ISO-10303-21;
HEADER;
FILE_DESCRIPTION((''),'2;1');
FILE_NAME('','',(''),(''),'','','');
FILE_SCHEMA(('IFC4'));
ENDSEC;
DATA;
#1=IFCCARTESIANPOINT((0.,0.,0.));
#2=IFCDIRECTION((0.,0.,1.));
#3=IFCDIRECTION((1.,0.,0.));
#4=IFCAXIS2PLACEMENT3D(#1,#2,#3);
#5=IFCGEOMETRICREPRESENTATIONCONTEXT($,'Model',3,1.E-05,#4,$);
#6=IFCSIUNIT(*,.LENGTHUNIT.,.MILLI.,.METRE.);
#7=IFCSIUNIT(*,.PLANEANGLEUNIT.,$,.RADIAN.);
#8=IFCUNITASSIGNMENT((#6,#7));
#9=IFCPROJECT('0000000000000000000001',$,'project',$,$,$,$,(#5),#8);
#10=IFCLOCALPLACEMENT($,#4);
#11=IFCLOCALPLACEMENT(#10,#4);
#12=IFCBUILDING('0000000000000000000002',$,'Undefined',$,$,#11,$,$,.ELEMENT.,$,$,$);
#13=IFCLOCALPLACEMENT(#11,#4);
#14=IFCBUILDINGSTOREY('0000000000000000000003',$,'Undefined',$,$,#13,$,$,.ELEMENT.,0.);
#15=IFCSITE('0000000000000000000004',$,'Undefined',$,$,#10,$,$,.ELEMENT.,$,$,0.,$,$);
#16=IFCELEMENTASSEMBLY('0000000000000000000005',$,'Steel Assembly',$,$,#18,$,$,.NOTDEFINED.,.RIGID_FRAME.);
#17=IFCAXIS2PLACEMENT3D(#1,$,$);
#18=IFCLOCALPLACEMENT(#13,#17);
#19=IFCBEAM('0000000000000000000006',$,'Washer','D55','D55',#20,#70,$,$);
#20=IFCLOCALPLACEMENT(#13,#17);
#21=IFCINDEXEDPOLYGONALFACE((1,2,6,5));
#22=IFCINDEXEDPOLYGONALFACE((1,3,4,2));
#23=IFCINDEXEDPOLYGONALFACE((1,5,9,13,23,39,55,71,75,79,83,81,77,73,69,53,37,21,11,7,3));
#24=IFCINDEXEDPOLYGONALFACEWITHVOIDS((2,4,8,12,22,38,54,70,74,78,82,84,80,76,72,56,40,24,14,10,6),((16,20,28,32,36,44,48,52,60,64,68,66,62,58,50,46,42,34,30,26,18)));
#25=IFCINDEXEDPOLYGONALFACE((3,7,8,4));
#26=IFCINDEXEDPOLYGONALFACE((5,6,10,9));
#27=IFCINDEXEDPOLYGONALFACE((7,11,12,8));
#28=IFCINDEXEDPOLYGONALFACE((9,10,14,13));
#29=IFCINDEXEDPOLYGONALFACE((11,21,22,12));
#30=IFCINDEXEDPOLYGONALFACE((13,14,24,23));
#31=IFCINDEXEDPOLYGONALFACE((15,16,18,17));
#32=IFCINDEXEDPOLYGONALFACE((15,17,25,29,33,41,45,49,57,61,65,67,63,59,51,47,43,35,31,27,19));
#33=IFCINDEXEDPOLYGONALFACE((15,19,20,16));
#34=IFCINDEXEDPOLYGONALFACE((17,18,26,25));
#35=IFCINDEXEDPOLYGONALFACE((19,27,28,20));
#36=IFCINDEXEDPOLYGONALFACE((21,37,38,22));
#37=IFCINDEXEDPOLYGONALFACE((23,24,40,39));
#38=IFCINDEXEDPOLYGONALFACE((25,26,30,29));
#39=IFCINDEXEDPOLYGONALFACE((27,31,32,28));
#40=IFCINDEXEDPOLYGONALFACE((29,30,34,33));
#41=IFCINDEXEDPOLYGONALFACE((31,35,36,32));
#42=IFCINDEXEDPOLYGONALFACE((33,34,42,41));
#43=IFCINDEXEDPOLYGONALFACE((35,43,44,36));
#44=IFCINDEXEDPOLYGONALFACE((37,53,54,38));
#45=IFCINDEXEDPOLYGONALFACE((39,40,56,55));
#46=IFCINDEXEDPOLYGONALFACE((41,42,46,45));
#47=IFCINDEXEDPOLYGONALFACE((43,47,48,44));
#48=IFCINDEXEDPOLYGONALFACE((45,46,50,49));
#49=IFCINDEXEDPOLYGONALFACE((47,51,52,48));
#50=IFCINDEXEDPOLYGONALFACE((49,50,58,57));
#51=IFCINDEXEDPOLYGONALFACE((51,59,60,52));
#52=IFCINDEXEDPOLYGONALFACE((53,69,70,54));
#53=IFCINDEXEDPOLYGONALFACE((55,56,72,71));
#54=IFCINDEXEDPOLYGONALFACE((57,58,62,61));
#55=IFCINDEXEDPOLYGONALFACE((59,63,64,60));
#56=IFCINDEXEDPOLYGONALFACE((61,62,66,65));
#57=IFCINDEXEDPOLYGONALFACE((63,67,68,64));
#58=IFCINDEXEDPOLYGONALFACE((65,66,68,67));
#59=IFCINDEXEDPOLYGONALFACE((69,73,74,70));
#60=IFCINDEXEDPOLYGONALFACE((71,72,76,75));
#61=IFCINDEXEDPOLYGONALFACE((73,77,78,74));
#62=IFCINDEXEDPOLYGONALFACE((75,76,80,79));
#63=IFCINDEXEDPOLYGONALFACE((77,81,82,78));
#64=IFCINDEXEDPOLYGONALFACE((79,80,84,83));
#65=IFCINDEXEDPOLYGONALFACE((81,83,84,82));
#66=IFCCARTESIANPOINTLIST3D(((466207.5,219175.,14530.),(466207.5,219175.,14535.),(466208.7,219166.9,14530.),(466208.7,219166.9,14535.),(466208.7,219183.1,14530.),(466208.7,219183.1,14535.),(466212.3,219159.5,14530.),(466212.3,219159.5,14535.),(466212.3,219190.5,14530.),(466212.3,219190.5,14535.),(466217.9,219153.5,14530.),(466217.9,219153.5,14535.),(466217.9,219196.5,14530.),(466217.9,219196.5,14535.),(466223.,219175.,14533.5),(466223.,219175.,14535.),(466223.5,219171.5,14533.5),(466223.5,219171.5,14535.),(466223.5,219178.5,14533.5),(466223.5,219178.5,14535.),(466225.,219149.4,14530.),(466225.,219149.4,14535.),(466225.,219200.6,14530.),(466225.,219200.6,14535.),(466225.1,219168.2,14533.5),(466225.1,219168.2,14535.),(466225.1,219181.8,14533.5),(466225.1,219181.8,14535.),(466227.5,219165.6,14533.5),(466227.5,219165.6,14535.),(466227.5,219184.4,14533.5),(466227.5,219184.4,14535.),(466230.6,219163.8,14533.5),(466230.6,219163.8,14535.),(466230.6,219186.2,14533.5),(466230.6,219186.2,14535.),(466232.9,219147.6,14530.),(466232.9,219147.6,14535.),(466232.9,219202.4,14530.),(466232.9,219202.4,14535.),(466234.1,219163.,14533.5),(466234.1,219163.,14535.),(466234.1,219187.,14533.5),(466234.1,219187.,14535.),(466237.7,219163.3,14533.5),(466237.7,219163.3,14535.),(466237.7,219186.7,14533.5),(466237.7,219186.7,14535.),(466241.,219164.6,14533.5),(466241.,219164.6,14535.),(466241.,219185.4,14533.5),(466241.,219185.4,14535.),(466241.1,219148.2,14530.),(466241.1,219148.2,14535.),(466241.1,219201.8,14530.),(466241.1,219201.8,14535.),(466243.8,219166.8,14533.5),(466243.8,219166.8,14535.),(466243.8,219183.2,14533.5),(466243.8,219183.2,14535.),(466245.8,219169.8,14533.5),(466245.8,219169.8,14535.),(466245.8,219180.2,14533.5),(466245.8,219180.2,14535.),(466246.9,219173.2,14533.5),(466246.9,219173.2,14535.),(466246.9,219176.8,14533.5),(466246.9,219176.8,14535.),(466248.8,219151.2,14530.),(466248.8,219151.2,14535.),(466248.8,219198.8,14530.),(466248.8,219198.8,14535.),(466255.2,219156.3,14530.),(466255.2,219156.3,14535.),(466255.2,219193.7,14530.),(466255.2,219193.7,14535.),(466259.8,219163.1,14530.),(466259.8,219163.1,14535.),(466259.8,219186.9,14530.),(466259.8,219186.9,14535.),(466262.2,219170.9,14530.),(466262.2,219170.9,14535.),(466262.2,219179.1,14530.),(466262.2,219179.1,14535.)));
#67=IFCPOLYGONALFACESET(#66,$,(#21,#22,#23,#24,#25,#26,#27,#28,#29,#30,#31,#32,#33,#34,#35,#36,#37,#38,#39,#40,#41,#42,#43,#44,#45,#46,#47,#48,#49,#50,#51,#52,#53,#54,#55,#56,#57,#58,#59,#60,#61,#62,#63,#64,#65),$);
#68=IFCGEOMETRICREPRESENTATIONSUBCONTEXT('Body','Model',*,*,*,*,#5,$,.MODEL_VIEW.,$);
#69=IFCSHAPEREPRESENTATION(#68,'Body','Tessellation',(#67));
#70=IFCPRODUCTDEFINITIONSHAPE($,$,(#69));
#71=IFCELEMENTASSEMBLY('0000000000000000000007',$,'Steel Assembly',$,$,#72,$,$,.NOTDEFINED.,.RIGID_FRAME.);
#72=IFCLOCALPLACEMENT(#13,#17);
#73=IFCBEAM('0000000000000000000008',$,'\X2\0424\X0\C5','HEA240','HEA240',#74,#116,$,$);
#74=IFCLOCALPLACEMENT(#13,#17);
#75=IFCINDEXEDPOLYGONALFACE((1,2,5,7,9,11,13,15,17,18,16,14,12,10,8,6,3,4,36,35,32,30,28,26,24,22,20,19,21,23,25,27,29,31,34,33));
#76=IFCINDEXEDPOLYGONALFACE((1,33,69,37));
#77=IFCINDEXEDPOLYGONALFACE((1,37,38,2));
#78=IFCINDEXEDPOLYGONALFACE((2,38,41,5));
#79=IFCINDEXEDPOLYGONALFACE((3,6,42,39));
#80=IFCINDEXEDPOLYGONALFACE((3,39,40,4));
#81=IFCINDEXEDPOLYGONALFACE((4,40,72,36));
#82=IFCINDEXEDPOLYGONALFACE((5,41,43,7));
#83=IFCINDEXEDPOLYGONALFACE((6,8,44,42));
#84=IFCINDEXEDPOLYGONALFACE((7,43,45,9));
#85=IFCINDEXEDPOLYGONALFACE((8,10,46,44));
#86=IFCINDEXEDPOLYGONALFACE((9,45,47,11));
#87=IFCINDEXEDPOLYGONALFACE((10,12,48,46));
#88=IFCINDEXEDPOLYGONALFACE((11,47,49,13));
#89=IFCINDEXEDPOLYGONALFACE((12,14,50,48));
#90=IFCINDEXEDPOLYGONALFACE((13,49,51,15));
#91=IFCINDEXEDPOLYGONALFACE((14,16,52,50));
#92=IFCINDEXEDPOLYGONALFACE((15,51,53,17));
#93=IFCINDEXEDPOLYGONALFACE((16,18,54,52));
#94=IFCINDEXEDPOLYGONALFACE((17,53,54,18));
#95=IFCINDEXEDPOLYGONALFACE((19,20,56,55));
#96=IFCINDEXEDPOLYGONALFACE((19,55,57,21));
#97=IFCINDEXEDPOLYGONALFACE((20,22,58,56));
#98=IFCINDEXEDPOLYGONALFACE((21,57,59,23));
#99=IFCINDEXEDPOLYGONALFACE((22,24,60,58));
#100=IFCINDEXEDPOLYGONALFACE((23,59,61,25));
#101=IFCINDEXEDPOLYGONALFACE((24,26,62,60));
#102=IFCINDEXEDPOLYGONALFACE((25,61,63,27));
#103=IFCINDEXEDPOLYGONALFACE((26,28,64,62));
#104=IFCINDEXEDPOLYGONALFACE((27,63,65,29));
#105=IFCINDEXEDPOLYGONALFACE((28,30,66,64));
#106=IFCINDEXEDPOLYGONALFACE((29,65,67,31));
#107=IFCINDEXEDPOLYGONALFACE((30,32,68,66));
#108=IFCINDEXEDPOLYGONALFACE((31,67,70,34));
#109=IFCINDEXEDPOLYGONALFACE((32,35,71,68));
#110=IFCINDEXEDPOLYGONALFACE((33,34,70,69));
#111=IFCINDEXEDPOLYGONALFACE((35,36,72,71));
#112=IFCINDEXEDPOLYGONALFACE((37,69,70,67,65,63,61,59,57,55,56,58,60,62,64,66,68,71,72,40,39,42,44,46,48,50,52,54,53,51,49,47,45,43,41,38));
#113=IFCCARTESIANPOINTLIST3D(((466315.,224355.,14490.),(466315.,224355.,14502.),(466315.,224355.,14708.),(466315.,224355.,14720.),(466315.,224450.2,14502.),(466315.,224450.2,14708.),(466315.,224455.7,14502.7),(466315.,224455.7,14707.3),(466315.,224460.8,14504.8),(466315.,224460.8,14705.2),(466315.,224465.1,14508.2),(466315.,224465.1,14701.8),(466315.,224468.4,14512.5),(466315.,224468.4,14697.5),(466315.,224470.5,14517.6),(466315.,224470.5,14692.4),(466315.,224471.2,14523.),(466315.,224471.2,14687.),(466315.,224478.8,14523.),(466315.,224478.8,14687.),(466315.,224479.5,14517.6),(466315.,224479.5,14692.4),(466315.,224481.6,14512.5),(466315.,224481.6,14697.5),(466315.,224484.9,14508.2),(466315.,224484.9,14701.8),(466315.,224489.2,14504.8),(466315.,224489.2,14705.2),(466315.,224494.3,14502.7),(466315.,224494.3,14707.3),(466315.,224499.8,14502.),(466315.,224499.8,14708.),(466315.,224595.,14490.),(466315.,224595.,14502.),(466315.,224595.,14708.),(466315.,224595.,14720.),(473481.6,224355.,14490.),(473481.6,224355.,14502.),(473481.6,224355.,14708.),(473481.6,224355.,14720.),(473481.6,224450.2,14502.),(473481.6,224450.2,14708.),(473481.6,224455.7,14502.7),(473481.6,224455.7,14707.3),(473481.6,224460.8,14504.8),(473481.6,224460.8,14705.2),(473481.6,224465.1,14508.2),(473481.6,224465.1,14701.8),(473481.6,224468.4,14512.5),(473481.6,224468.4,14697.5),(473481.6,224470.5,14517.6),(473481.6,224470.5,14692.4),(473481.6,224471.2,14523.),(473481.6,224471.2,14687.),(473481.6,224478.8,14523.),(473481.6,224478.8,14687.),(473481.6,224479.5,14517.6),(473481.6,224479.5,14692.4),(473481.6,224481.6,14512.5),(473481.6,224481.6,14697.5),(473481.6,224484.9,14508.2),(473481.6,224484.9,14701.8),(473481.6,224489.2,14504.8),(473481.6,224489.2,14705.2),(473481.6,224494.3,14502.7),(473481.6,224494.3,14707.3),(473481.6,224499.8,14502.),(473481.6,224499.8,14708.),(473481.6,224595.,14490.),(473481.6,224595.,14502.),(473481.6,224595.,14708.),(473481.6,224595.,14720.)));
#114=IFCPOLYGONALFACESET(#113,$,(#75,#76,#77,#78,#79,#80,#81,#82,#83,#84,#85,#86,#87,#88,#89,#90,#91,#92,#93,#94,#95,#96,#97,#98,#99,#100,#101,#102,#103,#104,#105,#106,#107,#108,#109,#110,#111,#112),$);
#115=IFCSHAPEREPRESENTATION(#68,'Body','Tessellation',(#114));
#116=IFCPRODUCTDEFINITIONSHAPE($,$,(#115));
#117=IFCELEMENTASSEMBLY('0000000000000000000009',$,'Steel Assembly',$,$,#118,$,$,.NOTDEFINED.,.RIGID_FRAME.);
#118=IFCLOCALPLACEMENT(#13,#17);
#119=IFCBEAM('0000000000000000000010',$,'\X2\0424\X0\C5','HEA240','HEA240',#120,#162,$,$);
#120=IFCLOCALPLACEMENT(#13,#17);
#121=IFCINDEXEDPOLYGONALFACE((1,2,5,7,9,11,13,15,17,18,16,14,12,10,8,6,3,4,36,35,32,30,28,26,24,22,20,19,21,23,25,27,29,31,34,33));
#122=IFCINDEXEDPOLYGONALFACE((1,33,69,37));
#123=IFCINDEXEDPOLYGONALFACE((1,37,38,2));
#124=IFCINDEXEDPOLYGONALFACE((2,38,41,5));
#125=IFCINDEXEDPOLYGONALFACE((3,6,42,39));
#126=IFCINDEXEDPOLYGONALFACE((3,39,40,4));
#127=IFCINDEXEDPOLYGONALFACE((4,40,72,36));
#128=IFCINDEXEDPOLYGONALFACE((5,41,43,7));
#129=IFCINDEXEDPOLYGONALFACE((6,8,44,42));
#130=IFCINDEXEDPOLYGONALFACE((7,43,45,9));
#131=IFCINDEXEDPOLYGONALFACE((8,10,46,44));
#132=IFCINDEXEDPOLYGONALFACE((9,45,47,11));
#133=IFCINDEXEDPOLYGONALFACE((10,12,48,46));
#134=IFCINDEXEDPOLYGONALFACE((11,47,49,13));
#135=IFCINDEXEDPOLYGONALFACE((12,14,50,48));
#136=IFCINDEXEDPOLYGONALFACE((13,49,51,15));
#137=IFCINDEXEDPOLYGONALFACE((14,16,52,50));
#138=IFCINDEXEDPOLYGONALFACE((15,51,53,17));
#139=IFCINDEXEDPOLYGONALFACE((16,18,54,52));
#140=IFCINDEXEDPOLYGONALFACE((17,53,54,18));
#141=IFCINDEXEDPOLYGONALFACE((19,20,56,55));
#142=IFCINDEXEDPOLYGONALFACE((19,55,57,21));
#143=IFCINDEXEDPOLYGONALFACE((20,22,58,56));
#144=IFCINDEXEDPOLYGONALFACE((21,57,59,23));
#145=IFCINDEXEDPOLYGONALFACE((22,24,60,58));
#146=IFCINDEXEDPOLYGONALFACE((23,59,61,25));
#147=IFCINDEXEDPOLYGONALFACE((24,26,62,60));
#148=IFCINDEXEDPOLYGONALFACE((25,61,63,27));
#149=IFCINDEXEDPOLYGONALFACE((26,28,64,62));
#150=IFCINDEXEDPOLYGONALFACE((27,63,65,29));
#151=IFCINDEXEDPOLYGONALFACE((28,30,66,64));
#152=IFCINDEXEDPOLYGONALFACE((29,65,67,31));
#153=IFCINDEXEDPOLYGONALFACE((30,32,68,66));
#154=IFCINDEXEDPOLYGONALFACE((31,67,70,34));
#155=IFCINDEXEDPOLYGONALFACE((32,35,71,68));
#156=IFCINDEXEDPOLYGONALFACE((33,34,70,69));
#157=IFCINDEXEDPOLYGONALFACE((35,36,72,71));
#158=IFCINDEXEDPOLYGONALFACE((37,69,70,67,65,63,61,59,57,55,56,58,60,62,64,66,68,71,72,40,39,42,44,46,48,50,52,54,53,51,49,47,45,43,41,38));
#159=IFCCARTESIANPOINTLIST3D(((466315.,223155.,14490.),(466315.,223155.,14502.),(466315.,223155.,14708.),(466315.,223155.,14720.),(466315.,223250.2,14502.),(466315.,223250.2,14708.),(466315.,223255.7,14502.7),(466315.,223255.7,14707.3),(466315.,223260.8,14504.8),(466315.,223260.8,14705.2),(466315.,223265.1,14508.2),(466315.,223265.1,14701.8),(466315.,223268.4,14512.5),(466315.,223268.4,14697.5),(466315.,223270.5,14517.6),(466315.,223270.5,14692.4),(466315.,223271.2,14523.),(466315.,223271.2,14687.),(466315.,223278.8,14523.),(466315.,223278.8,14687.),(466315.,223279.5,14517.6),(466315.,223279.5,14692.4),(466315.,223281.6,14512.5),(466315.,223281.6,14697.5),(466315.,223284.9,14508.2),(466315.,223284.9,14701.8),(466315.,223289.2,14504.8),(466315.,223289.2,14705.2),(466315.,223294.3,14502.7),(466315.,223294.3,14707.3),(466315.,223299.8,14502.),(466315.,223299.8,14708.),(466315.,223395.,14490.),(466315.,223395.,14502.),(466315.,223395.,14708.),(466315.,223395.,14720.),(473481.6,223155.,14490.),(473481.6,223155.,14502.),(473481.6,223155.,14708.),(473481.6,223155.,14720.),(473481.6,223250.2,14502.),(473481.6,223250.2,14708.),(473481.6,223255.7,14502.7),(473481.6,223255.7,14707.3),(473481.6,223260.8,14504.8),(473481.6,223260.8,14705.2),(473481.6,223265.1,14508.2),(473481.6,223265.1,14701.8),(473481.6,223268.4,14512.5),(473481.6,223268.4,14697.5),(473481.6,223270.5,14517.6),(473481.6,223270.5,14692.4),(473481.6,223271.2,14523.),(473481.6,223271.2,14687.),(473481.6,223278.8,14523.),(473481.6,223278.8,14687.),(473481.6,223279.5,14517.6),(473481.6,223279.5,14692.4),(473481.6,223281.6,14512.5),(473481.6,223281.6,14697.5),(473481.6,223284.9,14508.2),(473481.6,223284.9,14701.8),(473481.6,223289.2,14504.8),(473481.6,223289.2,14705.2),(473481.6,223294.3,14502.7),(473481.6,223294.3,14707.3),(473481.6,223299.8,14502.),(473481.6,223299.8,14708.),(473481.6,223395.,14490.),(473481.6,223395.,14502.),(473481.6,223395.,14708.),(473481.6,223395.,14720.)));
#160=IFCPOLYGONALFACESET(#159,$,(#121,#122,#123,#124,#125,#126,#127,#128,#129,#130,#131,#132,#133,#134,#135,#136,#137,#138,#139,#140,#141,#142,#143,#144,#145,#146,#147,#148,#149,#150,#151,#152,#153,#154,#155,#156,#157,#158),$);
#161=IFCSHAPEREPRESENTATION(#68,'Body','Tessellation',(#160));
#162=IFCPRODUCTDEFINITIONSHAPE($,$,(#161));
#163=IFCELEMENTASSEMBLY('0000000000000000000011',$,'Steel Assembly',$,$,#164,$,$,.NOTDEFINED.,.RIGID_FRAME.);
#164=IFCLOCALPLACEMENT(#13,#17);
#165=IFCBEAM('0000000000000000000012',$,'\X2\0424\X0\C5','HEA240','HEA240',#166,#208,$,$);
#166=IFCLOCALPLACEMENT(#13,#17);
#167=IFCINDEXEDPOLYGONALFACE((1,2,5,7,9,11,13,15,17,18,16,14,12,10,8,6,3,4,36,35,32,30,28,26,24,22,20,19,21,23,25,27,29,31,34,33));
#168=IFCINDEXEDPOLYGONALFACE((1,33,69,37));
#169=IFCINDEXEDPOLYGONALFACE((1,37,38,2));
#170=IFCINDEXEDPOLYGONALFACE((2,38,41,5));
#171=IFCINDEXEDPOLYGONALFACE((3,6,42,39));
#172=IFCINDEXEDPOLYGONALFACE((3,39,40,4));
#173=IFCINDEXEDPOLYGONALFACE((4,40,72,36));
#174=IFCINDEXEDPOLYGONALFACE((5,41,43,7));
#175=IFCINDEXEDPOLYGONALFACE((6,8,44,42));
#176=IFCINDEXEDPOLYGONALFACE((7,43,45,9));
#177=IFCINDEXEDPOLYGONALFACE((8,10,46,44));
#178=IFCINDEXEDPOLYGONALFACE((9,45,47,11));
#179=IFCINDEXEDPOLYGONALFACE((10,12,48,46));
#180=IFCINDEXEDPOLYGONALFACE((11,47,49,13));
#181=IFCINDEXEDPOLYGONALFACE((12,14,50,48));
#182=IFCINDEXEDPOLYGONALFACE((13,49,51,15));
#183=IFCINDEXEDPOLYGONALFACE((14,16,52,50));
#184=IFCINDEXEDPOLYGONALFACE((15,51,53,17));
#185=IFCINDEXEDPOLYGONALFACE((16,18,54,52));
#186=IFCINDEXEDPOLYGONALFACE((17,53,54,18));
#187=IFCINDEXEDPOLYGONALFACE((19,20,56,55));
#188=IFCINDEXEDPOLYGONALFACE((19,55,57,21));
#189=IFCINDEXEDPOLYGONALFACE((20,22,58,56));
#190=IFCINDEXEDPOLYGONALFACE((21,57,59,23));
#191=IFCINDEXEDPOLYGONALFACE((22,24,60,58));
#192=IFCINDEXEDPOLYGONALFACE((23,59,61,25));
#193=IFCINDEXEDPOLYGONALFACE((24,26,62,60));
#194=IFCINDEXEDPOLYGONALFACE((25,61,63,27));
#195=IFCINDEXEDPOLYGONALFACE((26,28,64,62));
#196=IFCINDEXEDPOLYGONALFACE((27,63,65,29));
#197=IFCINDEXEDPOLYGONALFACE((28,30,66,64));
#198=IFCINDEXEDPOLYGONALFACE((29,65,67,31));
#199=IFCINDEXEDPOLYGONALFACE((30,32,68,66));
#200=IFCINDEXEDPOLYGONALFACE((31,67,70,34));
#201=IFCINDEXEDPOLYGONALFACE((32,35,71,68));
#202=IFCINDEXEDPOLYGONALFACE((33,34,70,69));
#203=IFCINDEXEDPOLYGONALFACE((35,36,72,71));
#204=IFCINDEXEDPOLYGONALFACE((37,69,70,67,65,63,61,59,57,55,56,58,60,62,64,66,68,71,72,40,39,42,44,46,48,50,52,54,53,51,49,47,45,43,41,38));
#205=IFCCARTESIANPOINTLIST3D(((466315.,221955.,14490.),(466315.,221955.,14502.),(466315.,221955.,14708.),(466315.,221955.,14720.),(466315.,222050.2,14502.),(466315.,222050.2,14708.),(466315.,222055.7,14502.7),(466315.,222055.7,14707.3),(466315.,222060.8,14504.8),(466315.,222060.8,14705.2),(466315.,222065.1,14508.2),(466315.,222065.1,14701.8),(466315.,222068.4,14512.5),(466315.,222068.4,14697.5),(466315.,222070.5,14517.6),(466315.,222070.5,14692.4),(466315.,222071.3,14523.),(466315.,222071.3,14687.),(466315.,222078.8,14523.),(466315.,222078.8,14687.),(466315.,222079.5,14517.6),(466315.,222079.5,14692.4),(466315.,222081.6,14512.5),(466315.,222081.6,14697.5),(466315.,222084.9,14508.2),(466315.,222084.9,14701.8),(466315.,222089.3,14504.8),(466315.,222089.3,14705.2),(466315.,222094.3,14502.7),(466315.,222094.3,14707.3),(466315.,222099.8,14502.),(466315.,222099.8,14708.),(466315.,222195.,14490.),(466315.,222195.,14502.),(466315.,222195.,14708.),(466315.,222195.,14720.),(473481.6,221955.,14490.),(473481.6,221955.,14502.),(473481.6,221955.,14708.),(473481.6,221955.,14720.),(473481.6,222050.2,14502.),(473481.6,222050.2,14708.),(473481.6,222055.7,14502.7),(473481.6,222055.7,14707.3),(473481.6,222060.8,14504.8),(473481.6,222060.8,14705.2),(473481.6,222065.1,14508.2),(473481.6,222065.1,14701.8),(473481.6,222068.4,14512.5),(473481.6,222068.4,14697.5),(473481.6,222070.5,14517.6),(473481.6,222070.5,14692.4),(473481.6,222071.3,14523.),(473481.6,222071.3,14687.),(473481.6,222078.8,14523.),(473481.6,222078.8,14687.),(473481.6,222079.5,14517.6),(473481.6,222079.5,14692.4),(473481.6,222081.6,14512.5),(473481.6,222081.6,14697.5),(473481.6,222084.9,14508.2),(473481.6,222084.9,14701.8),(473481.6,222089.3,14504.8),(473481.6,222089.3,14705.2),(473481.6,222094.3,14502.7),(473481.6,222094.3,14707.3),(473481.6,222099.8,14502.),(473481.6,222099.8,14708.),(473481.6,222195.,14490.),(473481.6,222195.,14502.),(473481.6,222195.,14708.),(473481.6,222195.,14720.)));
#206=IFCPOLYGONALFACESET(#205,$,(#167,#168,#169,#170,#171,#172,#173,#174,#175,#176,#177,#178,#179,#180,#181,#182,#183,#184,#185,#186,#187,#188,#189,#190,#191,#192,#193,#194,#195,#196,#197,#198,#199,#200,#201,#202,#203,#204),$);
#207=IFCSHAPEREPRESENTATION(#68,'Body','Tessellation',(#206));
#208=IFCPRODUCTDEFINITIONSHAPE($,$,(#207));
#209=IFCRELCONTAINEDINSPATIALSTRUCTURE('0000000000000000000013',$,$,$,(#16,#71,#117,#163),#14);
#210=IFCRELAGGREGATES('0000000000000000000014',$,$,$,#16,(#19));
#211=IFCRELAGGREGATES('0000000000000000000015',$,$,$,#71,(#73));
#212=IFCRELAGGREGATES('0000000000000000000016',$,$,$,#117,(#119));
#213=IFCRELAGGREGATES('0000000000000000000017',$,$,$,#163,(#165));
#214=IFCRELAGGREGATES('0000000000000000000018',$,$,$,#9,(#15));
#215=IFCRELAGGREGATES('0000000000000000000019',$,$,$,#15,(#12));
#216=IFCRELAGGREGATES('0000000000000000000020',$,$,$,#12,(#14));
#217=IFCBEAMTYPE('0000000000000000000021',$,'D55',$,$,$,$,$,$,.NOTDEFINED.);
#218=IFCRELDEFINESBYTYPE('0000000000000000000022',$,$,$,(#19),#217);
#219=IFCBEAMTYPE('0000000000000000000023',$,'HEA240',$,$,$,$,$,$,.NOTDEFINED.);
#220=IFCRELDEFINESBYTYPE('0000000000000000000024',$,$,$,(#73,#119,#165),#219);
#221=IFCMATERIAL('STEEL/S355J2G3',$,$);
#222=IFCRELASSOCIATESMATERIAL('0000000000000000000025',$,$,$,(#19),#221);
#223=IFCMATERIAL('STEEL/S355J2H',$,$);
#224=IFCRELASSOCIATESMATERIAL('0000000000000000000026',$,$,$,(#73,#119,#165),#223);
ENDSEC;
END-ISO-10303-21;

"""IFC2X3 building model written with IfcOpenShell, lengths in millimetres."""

from ifc_helpers import new_model, si_unit, frame, origin_with_axes, origin_2d_with_axis, place, context, subcontext, project, spatial, circle, i_section, extrude, boolean, material, type_object, element, aggregate, save


model = new_model("IFC2X3")

# Units and contexts
model_context = context("Model", 3, precision=1e-05, world=origin_with_axes())
body_context = subcontext(model_context, "Body", "Model", "MODEL_VIEW")
ifc_project = project(units=[si_unit("LENGTHUNIT", "METRE", prefix="MILLI"), si_unit("PLANEANGLEUNIT", "RADIAN")], contexts=[model_context])

# Site, building, storey
site_placement = place(None, origin_with_axes())
site = spatial("IfcSite", under=ifc_project, at=site_placement, Name="Undefined", CompositionType="ELEMENT", RefElevation=0.0)
building_placement = place(site_placement, origin_with_axes())
building = spatial("IfcBuilding", under=site, at=building_placement, Name="Undefined", CompositionType="ELEMENT")
storey_placement = place(building_placement, origin_with_axes())
storey = spatial("IfcBuildingStorey", under=building, at=storey_placement, Name="Undefined", CompositionType="ELEMENT", Elevation=0.0)

# Element assemblies, beams
ifc_material_1 = material(Name="STEEL/S355J2G3")
assembly_1_placement = place(storey_placement, origin_with_axes())
assembly_1 = element("IfcElementAssembly", 1, at=assembly_1_placement, inside=storey, Name="Steel Assembly", AssemblyPlace="NOTDEFINED", PredefinedType="RIGID_FRAME")
beam_type_1 = type_object("IfcBeamType", Name="D55", PredefinedType="NOTDEFINED")
beam_1_placement = place(assembly_1_placement, frame((466235.0, 219175.0, 14535.0), z_axis=(0.0, -1.0, 0.0), x_axis=(0.0, 0.0, -1.0)))
beam_1 = element("IfcBeam", 2, at=beam_1_placement, type_object=beam_type_1, material=ifc_material_1, Name="Washer", Description="D55", ObjectType="D55", context=body_context, shape_type="CSG", body=[
    boolean("DIFFERENCE", extrude(circle(Radius=27.5, at=origin_2d_with_axis()), frame((5.0, 0.0, 0.0), z_axis=(-1.0, 0.0, 0.0), x_axis=(0.0, -1.0, 0.0)), (0.0, 0.0, 1.0), 5.0), extrude(circle(Radius=12.0, at=origin_2d_with_axis()), frame((1.5, 0.0, 0.0), z_axis=(-1.0, 0.0, 0.0), x_axis=(0.0, -1.0, 0.0)), (0.0, 0.0, 1.0), 10.0)),
])
aggregate(assembly_1, [beam_1])
assembly_2_placement = place(storey_placement, origin_with_axes())
assembly_2 = element("IfcElementAssembly", 3, at=assembly_2_placement, inside=storey, Name="Steel Assembly", AssemblyPlace="NOTDEFINED", PredefinedType="RIGID_FRAME")
ifc_material_2 = material(Name="STEEL/S355J2H")
beam_type_2 = type_object("IfcBeamType", Name="HEA240", PredefinedType="NOTDEFINED")
beam_2_placement = place(assembly_2_placement, frame((466315.0, 224475.0, 14605.0), z_axis=(0.0, 0.0, 1.0), x_axis=(1.0, 0.0, 0.0)))
beam_2 = element("IfcBeam", 4, at=beam_2_placement, type_object=beam_type_2, material=ifc_material_2, Name="ФC5", Description="HEA240", ObjectType="HEA240", context=body_context, shape_type="SweptSolid", body=[
    extrude(i_section(OverallWidth=240.0, OverallDepth=230.0, WebThickness=7.5, FlangeThickness=12.0, FilletRadius=21.0, at=origin_2d_with_axis()), frame((7166.6, 0.0, 0.0), z_axis=(-1.0, 0.0, 0.0), x_axis=(0.0, -1.0, 0.0)), (0.0, 0.0, 1.0), 7166.6),
])
aggregate(assembly_2, [beam_2])
assembly_3_placement = place(storey_placement, origin_with_axes())
assembly_3 = element("IfcElementAssembly", 5, at=assembly_3_placement, inside=storey, Name="Steel Assembly", AssemblyPlace="NOTDEFINED", PredefinedType="RIGID_FRAME")
beam_3_placement = place(assembly_3_placement, frame((466315.0, 223275.0, 14605.0), z_axis=(0.0, 0.0, 1.0), x_axis=(1.0, 0.0, 0.0)))
beam_3 = element("IfcBeam", 6, at=beam_3_placement, type_object=beam_type_2, material=ifc_material_2, Name="ФC5", Description="HEA240", ObjectType="HEA240", context=body_context, shape_type="SweptSolid", body=[
    extrude(i_section(OverallWidth=240.0, OverallDepth=230.0, WebThickness=7.5, FlangeThickness=12.0, FilletRadius=21.0, at=origin_2d_with_axis()), frame((7166.6, 0.0, 0.0), z_axis=(-1.0, 0.0, 0.0), x_axis=(0.0, -1.0, 0.0)), (0.0, 0.0, 1.0), 7166.6),
])
aggregate(assembly_3, [beam_3])
assembly_4_placement = place(storey_placement, origin_with_axes())
assembly_4 = element("IfcElementAssembly", 7, at=assembly_4_placement, inside=storey, Name="Steel Assembly", AssemblyPlace="NOTDEFINED", PredefinedType="RIGID_FRAME")
beam_4_placement = place(assembly_4_placement, frame((466315.0, 222075.0, 14605.0), z_axis=(0.0, 0.0, 1.0), x_axis=(1.0, 0.0, 0.0)))
beam_4 = element("IfcBeam", 8, at=beam_4_placement, type_object=beam_type_2, material=ifc_material_2, Name="ФC5", Description="HEA240", ObjectType="HEA240", context=body_context, shape_type="SweptSolid", body=[
    extrude(i_section(OverallWidth=240.0, OverallDepth=230.0, WebThickness=7.5, FlangeThickness=12.0, FilletRadius=21.0, at=origin_2d_with_axis()), frame((7166.6, 0.0, 0.0), z_axis=(-1.0, 0.0, 0.0), x_axis=(0.0, -1.0, 0.0)), (0.0, 0.0, 1.0), 7166.6),
])
aggregate(assembly_4, [beam_4])

save(model, "model.ifc")
